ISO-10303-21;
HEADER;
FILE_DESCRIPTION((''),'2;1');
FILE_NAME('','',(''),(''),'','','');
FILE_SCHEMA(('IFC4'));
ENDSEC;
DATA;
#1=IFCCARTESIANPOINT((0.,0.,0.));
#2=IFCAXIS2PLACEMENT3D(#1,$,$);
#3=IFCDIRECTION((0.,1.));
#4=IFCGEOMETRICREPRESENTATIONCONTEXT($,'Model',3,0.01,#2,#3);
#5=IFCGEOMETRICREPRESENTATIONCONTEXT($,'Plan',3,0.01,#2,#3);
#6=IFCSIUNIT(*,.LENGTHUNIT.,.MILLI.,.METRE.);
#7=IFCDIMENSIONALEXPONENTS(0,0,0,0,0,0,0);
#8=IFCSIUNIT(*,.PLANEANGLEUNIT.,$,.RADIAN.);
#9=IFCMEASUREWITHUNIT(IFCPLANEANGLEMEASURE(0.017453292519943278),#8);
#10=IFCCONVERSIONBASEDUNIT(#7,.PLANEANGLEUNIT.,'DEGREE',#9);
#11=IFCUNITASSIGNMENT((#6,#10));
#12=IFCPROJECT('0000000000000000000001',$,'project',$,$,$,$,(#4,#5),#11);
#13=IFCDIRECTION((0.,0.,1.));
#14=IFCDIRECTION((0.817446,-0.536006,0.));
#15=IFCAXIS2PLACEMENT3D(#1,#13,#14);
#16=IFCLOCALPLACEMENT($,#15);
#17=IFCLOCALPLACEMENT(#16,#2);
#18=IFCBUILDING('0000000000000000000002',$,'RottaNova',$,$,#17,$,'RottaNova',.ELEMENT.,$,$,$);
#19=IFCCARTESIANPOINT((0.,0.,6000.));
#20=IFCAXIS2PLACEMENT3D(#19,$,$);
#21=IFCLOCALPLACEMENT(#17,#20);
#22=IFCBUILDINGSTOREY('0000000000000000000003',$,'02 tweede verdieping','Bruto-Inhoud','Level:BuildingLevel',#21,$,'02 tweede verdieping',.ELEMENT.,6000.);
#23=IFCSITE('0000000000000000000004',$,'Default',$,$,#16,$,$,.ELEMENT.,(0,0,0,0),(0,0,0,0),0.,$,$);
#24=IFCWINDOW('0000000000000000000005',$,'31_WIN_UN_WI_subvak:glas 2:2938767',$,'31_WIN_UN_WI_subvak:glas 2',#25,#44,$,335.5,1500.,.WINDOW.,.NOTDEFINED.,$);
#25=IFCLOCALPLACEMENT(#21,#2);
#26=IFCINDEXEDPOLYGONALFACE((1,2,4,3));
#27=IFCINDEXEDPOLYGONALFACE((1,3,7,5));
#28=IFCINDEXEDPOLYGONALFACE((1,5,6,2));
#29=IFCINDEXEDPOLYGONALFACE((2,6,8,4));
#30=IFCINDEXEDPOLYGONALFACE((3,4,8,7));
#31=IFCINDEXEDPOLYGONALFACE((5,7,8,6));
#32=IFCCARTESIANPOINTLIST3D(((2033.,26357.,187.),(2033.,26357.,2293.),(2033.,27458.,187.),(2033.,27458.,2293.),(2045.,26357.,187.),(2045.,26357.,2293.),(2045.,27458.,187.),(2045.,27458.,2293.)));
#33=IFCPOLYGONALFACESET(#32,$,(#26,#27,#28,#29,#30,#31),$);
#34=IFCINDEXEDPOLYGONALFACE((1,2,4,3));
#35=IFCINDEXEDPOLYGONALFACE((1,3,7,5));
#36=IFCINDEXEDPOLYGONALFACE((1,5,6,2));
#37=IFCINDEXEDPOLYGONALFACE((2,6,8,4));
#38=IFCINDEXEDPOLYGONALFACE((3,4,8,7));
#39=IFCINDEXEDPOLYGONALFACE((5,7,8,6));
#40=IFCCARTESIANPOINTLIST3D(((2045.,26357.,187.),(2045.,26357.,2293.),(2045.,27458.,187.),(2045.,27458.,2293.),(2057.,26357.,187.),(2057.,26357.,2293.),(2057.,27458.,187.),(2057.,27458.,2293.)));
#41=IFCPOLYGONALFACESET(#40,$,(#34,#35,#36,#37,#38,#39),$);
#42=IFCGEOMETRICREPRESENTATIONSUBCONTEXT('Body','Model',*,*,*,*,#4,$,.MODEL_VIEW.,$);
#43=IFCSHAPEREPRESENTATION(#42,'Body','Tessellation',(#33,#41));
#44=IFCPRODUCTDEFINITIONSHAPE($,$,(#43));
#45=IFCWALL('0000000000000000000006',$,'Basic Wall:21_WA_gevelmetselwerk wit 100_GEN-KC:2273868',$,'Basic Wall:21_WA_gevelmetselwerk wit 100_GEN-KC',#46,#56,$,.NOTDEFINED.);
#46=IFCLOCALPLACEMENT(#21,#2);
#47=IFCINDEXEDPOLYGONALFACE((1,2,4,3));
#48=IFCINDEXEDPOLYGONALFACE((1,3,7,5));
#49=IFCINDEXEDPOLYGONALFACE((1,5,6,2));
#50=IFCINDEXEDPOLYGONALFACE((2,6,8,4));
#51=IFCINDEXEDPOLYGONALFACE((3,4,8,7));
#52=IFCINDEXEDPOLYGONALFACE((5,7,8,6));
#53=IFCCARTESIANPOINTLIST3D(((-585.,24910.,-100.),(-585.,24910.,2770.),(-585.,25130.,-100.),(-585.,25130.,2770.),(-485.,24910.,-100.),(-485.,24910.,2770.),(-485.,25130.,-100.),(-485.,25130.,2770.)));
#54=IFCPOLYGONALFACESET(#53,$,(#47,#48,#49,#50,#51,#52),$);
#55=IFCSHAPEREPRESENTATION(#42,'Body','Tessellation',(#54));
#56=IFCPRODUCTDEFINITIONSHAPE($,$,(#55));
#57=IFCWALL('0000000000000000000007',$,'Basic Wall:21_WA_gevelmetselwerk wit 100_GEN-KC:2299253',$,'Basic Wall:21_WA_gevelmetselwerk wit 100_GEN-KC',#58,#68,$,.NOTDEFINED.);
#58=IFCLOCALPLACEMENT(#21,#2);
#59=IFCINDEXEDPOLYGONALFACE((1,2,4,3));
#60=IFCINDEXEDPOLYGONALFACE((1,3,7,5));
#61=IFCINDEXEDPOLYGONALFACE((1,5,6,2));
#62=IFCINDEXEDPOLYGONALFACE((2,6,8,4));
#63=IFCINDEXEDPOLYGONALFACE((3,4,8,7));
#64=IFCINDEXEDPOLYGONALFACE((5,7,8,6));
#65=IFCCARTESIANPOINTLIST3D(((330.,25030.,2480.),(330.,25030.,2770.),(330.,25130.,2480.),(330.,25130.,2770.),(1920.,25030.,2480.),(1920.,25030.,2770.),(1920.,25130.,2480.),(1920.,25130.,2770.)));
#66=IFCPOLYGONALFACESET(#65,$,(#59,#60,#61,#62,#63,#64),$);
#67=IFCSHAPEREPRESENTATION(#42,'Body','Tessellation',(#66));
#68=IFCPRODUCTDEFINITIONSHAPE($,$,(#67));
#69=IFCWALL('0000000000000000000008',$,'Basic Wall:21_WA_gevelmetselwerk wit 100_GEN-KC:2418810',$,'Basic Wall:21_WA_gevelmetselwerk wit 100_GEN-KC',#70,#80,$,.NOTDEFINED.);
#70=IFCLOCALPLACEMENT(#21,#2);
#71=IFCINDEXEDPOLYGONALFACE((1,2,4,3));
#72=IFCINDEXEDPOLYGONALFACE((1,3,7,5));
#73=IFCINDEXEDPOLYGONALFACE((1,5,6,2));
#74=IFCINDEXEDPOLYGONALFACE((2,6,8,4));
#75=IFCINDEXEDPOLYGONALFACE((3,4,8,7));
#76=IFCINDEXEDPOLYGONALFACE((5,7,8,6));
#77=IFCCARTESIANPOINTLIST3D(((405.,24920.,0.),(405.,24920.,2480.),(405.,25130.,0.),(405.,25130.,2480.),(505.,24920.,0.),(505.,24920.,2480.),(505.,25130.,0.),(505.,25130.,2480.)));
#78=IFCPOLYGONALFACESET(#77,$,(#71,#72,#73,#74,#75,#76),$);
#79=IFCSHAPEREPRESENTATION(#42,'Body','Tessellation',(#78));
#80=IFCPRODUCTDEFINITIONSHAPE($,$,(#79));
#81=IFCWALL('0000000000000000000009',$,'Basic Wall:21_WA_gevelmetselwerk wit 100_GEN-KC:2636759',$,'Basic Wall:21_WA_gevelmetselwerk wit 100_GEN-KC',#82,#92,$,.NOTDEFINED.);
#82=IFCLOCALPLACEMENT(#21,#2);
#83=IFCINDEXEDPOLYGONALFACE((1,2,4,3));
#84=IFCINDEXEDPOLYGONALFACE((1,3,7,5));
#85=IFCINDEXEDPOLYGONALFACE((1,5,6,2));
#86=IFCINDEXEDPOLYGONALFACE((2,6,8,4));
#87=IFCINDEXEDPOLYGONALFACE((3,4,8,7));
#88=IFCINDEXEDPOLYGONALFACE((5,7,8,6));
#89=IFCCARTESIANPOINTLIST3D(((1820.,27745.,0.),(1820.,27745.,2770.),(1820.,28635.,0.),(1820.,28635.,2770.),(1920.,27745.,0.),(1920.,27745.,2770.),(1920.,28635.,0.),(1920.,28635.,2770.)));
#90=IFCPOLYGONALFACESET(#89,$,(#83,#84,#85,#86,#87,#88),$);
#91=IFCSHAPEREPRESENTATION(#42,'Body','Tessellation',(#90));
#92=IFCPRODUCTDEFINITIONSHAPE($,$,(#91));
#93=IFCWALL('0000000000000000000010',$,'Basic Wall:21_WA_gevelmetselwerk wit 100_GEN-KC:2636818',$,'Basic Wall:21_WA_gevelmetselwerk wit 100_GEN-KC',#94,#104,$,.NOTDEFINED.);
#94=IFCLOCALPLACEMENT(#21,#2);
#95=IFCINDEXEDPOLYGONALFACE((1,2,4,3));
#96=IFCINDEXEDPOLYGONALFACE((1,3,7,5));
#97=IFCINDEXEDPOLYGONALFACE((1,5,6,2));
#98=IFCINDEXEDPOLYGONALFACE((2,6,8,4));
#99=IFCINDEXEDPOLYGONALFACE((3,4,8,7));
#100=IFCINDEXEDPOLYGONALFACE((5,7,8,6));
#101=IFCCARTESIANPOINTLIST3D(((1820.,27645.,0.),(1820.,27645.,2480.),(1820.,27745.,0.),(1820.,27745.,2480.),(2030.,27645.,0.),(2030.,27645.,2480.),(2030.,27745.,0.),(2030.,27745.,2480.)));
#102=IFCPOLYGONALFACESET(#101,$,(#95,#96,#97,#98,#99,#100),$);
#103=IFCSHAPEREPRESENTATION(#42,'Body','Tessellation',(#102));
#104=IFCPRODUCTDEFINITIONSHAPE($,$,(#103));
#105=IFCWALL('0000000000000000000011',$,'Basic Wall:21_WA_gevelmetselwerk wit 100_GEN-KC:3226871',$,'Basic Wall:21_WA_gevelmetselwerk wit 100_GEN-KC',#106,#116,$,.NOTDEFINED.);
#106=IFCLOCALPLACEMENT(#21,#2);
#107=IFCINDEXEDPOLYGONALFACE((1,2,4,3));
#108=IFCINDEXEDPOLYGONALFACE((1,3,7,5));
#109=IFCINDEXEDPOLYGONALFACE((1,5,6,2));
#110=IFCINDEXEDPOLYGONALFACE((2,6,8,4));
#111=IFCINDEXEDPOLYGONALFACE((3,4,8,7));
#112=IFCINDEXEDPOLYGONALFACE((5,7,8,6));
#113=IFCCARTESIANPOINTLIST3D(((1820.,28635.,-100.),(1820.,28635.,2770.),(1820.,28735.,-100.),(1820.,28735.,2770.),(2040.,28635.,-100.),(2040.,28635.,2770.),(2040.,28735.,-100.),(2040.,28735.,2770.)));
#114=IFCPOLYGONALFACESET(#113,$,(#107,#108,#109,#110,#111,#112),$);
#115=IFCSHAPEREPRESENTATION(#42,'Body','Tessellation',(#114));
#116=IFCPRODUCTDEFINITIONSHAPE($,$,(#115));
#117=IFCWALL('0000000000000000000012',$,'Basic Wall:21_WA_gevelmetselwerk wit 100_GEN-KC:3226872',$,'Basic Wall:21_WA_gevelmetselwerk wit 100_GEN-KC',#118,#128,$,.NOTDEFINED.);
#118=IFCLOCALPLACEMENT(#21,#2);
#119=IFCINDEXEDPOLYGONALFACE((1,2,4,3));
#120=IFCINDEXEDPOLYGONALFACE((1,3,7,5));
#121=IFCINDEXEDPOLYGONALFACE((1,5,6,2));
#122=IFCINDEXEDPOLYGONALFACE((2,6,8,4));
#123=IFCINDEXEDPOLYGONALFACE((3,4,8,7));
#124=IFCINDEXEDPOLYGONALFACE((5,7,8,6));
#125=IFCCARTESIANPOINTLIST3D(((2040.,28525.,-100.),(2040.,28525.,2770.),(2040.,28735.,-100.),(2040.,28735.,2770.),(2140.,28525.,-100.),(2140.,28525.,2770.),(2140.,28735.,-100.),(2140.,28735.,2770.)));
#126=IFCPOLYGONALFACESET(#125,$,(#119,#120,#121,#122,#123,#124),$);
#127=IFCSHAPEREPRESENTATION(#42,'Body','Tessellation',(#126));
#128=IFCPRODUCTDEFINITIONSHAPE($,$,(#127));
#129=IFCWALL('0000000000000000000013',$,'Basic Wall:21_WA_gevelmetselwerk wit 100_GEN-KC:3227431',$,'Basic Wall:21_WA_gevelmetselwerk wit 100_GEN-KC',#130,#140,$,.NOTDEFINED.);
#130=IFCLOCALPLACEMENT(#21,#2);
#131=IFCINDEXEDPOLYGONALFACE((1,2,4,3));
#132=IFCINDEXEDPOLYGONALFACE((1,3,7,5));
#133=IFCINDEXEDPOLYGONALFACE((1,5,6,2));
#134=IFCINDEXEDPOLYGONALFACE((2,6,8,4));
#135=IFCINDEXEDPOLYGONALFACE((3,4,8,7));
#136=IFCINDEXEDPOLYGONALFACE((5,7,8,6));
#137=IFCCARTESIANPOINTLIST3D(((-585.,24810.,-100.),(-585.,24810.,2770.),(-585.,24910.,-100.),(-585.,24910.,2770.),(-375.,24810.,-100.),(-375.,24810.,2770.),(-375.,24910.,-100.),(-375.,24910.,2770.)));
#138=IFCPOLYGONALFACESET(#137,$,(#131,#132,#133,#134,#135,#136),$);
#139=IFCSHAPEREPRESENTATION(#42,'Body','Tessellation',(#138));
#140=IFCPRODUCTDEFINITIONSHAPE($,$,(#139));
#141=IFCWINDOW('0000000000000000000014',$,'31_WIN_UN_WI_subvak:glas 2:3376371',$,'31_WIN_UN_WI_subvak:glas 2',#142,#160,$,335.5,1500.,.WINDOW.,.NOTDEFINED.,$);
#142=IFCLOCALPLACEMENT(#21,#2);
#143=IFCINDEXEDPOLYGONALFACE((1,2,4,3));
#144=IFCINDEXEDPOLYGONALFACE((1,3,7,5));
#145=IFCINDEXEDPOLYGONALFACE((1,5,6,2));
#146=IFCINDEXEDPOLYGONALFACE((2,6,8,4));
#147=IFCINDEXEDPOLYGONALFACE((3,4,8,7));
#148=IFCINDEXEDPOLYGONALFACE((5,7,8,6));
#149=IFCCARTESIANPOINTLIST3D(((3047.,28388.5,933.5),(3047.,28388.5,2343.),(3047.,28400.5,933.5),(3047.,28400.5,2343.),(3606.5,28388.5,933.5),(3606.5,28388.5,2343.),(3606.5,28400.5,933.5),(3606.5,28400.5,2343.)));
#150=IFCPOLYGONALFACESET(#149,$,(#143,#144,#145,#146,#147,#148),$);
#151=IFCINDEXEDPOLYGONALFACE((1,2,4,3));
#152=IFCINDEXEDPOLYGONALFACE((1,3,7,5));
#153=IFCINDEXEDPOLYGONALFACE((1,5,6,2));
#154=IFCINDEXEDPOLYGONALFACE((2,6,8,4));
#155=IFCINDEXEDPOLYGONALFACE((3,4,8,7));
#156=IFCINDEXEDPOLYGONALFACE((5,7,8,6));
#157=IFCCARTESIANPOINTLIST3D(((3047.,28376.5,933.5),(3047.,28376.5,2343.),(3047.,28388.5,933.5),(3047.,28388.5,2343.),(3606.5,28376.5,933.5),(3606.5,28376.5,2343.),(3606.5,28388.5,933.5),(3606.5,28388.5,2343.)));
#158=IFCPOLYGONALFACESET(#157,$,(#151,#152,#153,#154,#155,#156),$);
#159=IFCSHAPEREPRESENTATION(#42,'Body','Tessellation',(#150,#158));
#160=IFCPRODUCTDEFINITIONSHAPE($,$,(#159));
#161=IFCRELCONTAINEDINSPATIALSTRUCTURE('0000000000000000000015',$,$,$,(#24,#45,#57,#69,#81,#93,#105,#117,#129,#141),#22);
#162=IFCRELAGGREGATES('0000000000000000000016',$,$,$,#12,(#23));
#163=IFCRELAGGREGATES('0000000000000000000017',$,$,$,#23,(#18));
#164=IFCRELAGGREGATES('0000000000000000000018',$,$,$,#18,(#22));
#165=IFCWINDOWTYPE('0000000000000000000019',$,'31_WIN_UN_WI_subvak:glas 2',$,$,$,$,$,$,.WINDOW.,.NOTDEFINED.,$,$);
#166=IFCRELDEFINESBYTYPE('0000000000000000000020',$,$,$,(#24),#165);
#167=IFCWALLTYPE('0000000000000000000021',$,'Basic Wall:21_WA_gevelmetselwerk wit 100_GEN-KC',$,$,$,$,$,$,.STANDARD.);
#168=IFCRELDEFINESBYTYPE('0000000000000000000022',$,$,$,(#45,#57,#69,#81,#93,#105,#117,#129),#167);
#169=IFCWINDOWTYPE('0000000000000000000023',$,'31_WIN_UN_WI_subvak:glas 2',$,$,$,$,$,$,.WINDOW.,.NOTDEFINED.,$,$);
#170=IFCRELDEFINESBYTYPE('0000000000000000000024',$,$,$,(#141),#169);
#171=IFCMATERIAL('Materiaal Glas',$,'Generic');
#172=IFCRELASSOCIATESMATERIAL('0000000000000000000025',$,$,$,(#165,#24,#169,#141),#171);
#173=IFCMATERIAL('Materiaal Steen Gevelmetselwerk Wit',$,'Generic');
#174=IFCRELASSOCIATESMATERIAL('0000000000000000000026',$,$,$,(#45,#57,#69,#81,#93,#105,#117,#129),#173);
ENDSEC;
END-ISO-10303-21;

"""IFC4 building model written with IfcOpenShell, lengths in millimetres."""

from ifc_helpers import new_model, entity, si_unit, converted_unit, direction, frame, origin, place, context, subcontext, project, spatial, indexed_curve, outline, extrude, source, transform, mapped, material, type_object, type_shapes, element, save


model = new_model("IFC4")

# Units and contexts
model_context = context("Model", 3, precision=0.01, world=origin(), true_north=direction((0.0, 1.0)))
plan_context = context("Plan", 3, precision=0.01, world=origin(), true_north=direction((0.0, 1.0)))
body_context = subcontext(model_context, "Body", "Model", "MODEL_VIEW")
ifc_project = project(units=[si_unit("LENGTHUNIT", "METRE", prefix="MILLI"), converted_unit("PLANEANGLEUNIT", "DEGREE", entity("IfcPlaneAngleMeasure", 0.017453292519943278), si_unit("PLANEANGLEUNIT", "RADIAN"), dimensions=[0, 0, 0, 0, 0, 0, 0])], contexts=[model_context, plan_context])

# Site, building, storey
site_placement = place(None, frame((0.0, 0.0, 0.0), z_axis=(0.0, 0.0, 1.0), x_axis=(0.817446, -0.536006, 0.0)))
site = spatial("IfcSite", under=ifc_project, at=site_placement, Name="Default", CompositionType="ELEMENT", RefLatitude=(0, 0, 0, 0), RefLongitude=(0, 0, 0, 0), RefElevation=0.0)
building_placement = place(site_placement, origin())
building = spatial("IfcBuilding", under=site, at=building_placement, Name="RottaNova", LongName="RottaNova", CompositionType="ELEMENT")
storey_placement = place(building_placement, frame((0.0, 0.0, 6000.0)))
storey = spatial("IfcBuildingStorey", under=building, at=storey_placement, Name="02 tweede verdieping", Description="Bruto-Inhoud", ObjectType="Level:BuildingLevel", LongName="02 tweede verdieping", CompositionType="ELEMENT", Elevation=6000.0)

# Shared definitions
ifc_material_1 = material(Name="Materiaal Glas", Category="Generic")

# Window
window_type_1 = type_object("IfcWindowType", Name="31_WIN_UN_WI_subvak:glas 2", PartitioningType="NOTDEFINED", PredefinedType="WINDOW", material=ifc_material_1)
shared_shape_1 = source(origin(), body_context, "Body", "SweptSolid", [
    extrude(outline(indexed_curve([(-550.5, -6.0), (550.5, -6.0), (550.5, 6.0), (-550.5, 6.0), (-550.5, -6.0)], self_intersect=False)), frame((0.0, -6.0, 0.0)), (0.0, 0.0, 1.0), 2106.0),
    extrude(outline(indexed_curve([(-550.5, -6.0), (550.5, -6.0), (550.5, 6.0), (-550.5, 6.0), (-550.5, -6.0)], self_intersect=False)), frame((0.0, 6.0, 0.0)), (0.0, 0.0, 1.0), 2106.0),
])
type_shapes(window_type_1, [shared_shape_1])
window_1_placement = place(storey_placement, frame((2045.0, 26907.5, 187.0), z_axis=(0.0, 0.0, 1.0), x_axis=(0.0, -1.0, 0.0)))
element("IfcWindow", 1, at=window_1_placement, inside=storey, type_object=window_type_1, material=ifc_material_1, Name="31_WIN_UN_WI_subvak:glas 2:2938767", ObjectType="31_WIN_UN_WI_subvak:glas 2", OverallHeight=335.5, OverallWidth=1500.0, PartitioningType="NOTDEFINED", PredefinedType="WINDOW", context=body_context, shape_type="MappedRepresentation", body=[
    mapped(shared_shape_1, transform((0.0, 0.0, 0.0), scale=1.0)),
])

# Walls
ifc_material_2 = material(Name="Materiaal Steen Gevelmetselwerk Wit", Category="Generic")
wall_type_1 = type_object("IfcWallType", Name="Basic Wall:21_WA_gevelmetselwerk wit 100_GEN-KC", PredefinedType="STANDARD")
wall_1_placement = place(storey_placement, frame((-535.0, 25130.0, -100.0), z_axis=(0.0, 0.0, 1.0), x_axis=(0.0, -1.0, 0.0)))
element("IfcWall", 2, at=wall_1_placement, inside=storey, type_object=wall_type_1, material=ifc_material_2, Name="Basic Wall:21_WA_gevelmetselwerk wit 100_GEN-KC:2273868", ObjectType="Basic Wall:21_WA_gevelmetselwerk wit 100_GEN-KC", PredefinedType="NOTDEFINED", context=body_context, shape_type="SweptSolid", body=[
    extrude(outline(indexed_curve([(220.0, 50.0), (0.0, 50.0), (0.0, -50.0), (220.0, -50.0), (220.0, 50.0)], self_intersect=False)), origin(), (0.0, 0.0, 1.0), 2870.0),
])
wall_2_placement = place(storey_placement, frame((330.0, 25080.0, 2480.0)))
element("IfcWall", 3, at=wall_2_placement, inside=storey, type_object=wall_type_1, material=ifc_material_2, Name="Basic Wall:21_WA_gevelmetselwerk wit 100_GEN-KC:2299253", ObjectType="Basic Wall:21_WA_gevelmetselwerk wit 100_GEN-KC", PredefinedType="NOTDEFINED", context=body_context, shape_type="SweptSolid", body=[
    extrude(outline(indexed_curve([(1590.0, 50.0), (0.0, 50.0), (0.0, -50.0), (1590.0, -50.0), (1590.0, 50.0)], self_intersect=False)), origin(), (0.0, 0.0, 1.0), 290.0),
])
wall_3_placement = place(storey_placement, frame((455.0, 24920.0, 0.0), z_axis=(0.0, 0.0, 1.0), x_axis=(0.0, 1.0, 0.0)))
element("IfcWall", 4, at=wall_3_placement, inside=storey, type_object=wall_type_1, material=ifc_material_2, Name="Basic Wall:21_WA_gevelmetselwerk wit 100_GEN-KC:2418810", ObjectType="Basic Wall:21_WA_gevelmetselwerk wit 100_GEN-KC", PredefinedType="NOTDEFINED", context=body_context, shape_type="SweptSolid", body=[
    extrude(outline(indexed_curve([(210.0, 50.0), (0.0, 50.0), (0.0, -50.0), (210.0, -50.0), (210.0, 50.0)], self_intersect=False)), origin(), (0.0, 0.0, 1.0), 2480.0),
])
wall_4_placement = place(storey_placement, frame((1870.0, 27745.0, 0.0), z_axis=(0.0, 0.0, 1.0), x_axis=(0.0, 1.0, 0.0)))
element("IfcWall", 5, at=wall_4_placement, inside=storey, type_object=wall_type_1, material=ifc_material_2, Name="Basic Wall:21_WA_gevelmetselwerk wit 100_GEN-KC:2636759", ObjectType="Basic Wall:21_WA_gevelmetselwerk wit 100_GEN-KC", PredefinedType="NOTDEFINED", context=body_context, shape_type="SweptSolid", body=[
    extrude(outline(indexed_curve([(890.0, 50.0), (0.0, 50.0), (0.0, -50.0), (890.0, -50.0), (890.0, 50.0)], self_intersect=False)), origin(), (0.0, 0.0, 1.0), 2770.0),
])
wall_5_placement = place(storey_placement, frame((2030.0, 27695.0, 0.0), z_axis=(0.0, 0.0, 1.0), x_axis=(-1.0, 0.0, 0.0)))
element("IfcWall", 6, at=wall_5_placement, inside=storey, type_object=wall_type_1, material=ifc_material_2, Name="Basic Wall:21_WA_gevelmetselwerk wit 100_GEN-KC:2636818", ObjectType="Basic Wall:21_WA_gevelmetselwerk wit 100_GEN-KC", PredefinedType="NOTDEFINED", context=body_context, shape_type="SweptSolid", body=[
    extrude(outline(indexed_curve([(210.0, 50.0), (0.0, 50.0), (0.0, -50.0), (210.0, -50.0), (210.0, 50.0)], self_intersect=False)), origin(), (0.0, 0.0, 1.0), 2480.0),
])
wall_6_placement = place(storey_placement, frame((2040.0, 28685.0, -100.0), z_axis=(0.0, 0.0, 1.0), x_axis=(-1.0, 0.0, 0.0)))
element("IfcWall", 7, at=wall_6_placement, inside=storey, type_object=wall_type_1, material=ifc_material_2, Name="Basic Wall:21_WA_gevelmetselwerk wit 100_GEN-KC:3226871", ObjectType="Basic Wall:21_WA_gevelmetselwerk wit 100_GEN-KC", PredefinedType="NOTDEFINED", context=body_context, shape_type="SweptSolid", body=[
    extrude(outline(indexed_curve([(220.0, 50.0), (0.0, 50.0), (0.0, -50.0), (220.0, -50.0), (220.0, 50.0)], self_intersect=False)), origin(), (0.0, 0.0, 1.0), 2870.0),
])
wall_7_placement = place(storey_placement, frame((2090.0, 28735.0, -100.0), z_axis=(0.0, 0.0, 1.0), x_axis=(0.0, -1.0, 0.0)))
element("IfcWall", 8, at=wall_7_placement, inside=storey, type_object=wall_type_1, material=ifc_material_2, Name="Basic Wall:21_WA_gevelmetselwerk wit 100_GEN-KC:3226872", ObjectType="Basic Wall:21_WA_gevelmetselwerk wit 100_GEN-KC", PredefinedType="NOTDEFINED", context=body_context, shape_type="SweptSolid", body=[
    extrude(outline(indexed_curve([(210.0, 50.0), (0.0, 50.0), (0.0, -50.0), (210.0, -50.0), (210.0, 50.0)], self_intersect=False)), origin(), (0.0, 0.0, 1.0), 2870.0),
])
wall_8_placement = place(storey_placement, frame((-585.0, 24860.0, -100.0)))
element("IfcWall", 9, at=wall_8_placement, inside=storey, type_object=wall_type_1, material=ifc_material_2, Name="Basic Wall:21_WA_gevelmetselwerk wit 100_GEN-KC:3227431", ObjectType="Basic Wall:21_WA_gevelmetselwerk wit 100_GEN-KC", PredefinedType="NOTDEFINED", context=body_context, shape_type="SweptSolid", body=[
    extrude(outline(indexed_curve([(210.0, 50.0), (0.0, 50.0), (0.0, -50.0), (210.0, -50.0), (210.0, 50.0)], self_intersect=False)), origin(), (0.0, 0.0, 1.0), 2870.0),
])

# Window
window_type_2 = type_object("IfcWindowType", Name="31_WIN_UN_WI_subvak:glas 2", PartitioningType="NOTDEFINED", PredefinedType="WINDOW", material=ifc_material_1)
shared_shape_2 = source(origin(), body_context, "Body", "SweptSolid", [
    extrude(outline(indexed_curve([(-279.8, -6.0), (279.8, -6.0), (279.8, 6.0), (-279.8, 6.0), (-279.8, -6.0)], self_intersect=False)), frame((0.0, -6.0, 0.0)), (0.0, 0.0, 1.0), 1409.5),
    extrude(outline(indexed_curve([(-279.8, -6.0), (279.8, -6.0), (279.8, 6.0), (-279.8, 6.0), (-279.8, -6.0)], self_intersect=False)), frame((0.0, 6.0, 0.0)), (0.0, 0.0, 1.0), 1409.5),
])
type_shapes(window_type_2, [shared_shape_2])
window_2_placement = place(storey_placement, frame((3326.7, 28388.5, 933.5), z_axis=(0.0, 0.0, 1.0), x_axis=(-1.0, 0.0, 0.0)))
element("IfcWindow", 10, at=window_2_placement, inside=storey, type_object=window_type_2, material=ifc_material_1, Name="31_WIN_UN_WI_subvak:glas 2:3376371", ObjectType="31_WIN_UN_WI_subvak:glas 2", OverallHeight=335.5, OverallWidth=1500.0, PartitioningType="NOTDEFINED", PredefinedType="WINDOW", context=body_context, shape_type="MappedRepresentation", body=[
    mapped(shared_shape_2, transform((0.0, 0.0, 0.0), scale=1.0)),
])

save(model, "model.ifc")
